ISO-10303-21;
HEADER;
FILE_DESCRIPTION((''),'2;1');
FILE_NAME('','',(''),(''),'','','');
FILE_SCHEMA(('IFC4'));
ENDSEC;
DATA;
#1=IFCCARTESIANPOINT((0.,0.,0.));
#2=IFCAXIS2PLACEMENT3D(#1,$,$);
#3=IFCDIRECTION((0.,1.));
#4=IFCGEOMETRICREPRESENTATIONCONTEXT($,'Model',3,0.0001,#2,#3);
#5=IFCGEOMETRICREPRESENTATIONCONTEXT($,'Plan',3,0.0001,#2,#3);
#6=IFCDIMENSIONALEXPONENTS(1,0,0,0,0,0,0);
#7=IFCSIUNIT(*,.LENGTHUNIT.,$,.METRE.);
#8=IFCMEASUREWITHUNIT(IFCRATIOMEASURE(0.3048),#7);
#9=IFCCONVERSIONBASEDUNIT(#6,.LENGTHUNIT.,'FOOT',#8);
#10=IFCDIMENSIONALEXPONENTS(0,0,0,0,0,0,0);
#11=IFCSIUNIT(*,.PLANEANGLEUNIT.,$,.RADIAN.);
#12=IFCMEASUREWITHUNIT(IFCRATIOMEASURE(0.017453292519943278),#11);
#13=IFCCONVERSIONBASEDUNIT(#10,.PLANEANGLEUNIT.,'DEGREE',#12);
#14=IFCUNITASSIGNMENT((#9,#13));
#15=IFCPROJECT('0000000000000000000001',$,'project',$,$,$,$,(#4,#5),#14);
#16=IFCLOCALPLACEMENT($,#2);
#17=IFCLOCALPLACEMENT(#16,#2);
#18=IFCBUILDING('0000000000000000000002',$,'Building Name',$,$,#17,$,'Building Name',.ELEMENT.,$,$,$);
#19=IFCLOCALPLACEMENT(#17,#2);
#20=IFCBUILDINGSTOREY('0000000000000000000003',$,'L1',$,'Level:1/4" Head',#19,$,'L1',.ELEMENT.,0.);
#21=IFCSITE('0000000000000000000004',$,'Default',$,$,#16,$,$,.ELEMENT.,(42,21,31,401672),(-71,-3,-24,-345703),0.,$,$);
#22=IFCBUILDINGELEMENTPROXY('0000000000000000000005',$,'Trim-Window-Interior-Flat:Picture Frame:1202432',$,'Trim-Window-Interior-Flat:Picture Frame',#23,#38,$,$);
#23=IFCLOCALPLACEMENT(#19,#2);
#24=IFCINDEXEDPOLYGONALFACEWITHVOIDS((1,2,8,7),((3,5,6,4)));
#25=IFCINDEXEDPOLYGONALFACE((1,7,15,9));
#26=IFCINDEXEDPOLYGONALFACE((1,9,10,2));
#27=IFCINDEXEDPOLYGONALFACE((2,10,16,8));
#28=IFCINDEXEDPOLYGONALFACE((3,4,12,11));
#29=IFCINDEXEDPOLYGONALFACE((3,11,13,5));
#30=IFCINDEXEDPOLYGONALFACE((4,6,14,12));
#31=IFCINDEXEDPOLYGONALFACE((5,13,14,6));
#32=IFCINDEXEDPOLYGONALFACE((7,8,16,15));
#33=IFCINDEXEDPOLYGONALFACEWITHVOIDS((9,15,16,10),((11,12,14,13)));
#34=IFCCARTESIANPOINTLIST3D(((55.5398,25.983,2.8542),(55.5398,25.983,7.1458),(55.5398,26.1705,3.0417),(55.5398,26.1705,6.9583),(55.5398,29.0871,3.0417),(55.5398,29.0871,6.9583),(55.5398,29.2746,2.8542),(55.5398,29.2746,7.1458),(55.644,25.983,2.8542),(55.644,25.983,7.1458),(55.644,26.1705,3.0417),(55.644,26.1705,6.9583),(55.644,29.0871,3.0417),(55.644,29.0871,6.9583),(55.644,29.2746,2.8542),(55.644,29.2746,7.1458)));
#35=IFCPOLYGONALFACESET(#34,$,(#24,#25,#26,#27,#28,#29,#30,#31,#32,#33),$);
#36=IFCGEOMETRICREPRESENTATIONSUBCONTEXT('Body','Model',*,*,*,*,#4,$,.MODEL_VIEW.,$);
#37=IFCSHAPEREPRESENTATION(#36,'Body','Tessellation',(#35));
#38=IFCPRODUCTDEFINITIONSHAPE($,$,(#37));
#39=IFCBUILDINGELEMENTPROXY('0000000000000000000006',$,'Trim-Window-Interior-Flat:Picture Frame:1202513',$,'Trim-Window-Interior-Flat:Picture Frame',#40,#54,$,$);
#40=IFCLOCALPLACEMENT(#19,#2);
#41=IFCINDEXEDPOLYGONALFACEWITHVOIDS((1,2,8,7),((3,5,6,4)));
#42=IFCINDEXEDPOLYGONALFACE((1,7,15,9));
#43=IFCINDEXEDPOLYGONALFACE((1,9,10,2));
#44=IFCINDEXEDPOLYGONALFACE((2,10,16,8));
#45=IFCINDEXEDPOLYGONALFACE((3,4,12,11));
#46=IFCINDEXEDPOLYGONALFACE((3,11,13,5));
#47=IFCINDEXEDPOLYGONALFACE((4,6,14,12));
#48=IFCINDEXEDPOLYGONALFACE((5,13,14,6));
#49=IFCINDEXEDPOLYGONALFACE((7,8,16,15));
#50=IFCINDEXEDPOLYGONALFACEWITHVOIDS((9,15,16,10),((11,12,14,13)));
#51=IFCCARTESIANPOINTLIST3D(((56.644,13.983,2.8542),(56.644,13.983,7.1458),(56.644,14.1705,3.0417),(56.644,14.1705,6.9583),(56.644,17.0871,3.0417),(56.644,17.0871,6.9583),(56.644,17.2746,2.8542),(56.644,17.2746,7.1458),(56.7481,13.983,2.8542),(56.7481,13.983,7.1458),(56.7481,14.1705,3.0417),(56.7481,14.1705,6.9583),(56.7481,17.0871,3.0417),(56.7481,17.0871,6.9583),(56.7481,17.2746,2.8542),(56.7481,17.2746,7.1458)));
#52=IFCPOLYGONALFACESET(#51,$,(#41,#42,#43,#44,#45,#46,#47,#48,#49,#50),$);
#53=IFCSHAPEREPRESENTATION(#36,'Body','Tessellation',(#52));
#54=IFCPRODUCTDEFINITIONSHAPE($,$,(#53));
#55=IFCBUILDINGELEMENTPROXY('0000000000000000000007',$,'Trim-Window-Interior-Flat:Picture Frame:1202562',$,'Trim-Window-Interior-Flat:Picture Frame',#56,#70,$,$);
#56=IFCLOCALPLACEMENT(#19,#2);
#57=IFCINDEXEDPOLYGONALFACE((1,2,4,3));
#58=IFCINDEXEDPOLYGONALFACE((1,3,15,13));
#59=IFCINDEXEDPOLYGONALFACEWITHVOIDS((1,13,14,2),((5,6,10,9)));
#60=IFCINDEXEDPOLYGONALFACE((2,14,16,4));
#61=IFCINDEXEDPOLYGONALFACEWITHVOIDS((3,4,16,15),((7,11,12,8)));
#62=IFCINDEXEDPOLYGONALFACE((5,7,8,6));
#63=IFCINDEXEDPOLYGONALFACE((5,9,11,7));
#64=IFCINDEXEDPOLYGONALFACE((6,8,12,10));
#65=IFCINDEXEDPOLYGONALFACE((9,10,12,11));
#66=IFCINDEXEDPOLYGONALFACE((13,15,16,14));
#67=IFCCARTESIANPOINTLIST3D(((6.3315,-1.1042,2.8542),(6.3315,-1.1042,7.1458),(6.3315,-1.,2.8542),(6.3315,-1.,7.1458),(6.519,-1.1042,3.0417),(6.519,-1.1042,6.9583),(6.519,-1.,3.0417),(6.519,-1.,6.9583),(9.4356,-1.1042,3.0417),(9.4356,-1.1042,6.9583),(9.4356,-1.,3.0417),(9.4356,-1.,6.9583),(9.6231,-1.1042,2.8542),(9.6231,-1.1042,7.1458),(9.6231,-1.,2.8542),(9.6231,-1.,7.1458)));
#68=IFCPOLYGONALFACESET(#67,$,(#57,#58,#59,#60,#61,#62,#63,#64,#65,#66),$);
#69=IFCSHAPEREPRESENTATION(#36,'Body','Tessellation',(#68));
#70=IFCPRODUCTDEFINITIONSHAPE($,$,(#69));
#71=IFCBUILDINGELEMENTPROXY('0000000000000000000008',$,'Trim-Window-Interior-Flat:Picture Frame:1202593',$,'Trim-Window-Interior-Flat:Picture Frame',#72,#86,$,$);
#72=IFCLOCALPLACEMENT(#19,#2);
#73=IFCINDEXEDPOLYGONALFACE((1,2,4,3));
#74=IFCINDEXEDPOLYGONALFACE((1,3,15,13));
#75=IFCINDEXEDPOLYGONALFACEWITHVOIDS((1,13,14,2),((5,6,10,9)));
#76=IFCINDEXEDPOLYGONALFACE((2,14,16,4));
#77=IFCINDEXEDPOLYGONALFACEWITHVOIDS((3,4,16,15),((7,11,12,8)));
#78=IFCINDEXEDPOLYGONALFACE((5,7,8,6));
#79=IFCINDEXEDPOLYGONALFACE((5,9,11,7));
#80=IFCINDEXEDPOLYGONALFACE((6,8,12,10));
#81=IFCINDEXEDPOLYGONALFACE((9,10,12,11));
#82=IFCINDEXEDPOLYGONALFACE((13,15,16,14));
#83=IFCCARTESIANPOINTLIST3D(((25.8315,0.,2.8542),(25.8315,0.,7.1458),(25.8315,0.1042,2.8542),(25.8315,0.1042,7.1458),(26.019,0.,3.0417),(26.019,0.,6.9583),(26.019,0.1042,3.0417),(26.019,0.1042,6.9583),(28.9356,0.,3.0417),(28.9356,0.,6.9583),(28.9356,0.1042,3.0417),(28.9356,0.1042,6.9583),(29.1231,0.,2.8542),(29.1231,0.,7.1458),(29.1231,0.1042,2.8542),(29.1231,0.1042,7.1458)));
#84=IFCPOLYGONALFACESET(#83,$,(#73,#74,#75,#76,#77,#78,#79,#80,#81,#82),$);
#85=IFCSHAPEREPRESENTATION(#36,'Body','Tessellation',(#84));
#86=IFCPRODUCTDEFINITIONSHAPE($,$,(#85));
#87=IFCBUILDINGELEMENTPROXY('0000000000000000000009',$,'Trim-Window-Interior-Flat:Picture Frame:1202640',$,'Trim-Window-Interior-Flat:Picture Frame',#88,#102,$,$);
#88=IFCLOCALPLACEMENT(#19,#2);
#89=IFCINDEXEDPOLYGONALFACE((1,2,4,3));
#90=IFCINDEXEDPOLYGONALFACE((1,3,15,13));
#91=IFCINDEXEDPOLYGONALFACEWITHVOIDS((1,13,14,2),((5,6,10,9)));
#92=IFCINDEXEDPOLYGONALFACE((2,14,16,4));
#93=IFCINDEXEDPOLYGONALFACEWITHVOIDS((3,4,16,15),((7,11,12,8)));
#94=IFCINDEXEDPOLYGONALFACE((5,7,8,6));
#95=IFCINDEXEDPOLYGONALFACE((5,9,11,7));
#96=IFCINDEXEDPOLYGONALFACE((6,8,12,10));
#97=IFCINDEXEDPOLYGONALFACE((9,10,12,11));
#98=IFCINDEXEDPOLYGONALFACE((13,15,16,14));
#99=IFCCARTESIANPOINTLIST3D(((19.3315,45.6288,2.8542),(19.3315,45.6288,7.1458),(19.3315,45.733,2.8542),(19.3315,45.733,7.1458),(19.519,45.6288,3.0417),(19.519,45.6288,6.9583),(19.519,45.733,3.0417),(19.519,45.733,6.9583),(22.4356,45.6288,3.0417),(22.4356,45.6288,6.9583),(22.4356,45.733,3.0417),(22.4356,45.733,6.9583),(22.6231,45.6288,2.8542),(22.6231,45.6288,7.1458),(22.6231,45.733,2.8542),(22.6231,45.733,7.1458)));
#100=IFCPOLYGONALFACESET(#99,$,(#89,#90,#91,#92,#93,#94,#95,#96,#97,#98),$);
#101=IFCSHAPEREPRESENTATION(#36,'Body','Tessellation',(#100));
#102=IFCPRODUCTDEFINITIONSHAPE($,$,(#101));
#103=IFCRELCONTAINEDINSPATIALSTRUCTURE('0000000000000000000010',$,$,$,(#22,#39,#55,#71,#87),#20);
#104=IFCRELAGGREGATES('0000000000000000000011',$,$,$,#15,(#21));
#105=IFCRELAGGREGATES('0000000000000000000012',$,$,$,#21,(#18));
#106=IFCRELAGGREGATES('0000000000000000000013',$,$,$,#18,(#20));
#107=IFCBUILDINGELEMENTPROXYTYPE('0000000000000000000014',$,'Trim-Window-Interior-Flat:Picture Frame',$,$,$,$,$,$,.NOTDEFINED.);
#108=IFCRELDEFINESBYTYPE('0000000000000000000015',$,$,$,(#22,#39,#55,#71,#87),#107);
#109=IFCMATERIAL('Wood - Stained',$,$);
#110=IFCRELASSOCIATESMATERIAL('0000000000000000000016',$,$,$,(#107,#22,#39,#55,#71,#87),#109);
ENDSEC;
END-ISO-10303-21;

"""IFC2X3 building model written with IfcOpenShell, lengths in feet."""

from ifc_helpers import new_model, entity, si_unit, converted_unit, direction, frame, origin, place, context, subcontext, project, spatial, polyline, outline, extrude, source, transform, mapped, material, type_object, type_shapes, element, save


model = new_model("IFC2X3")

# Units and contexts
model_context = context("Model", 3, precision=0.0001, world=origin(), true_north=direction((0.0, 1.0)))
plan_context = context("Plan", 3, precision=0.0001, world=origin(), true_north=direction((0.0, 1.0)))
body_context = subcontext(model_context, "Body", "Model", "MODEL_VIEW")
ifc_project = project(units=[converted_unit("LENGTHUNIT", "FOOT", entity("IfcRatioMeasure", 0.3048), si_unit("LENGTHUNIT", "METRE"), dimensions=[1, 0, 0, 0, 0, 0, 0]), converted_unit("PLANEANGLEUNIT", "DEGREE", entity("IfcRatioMeasure", 0.017453292519943278), si_unit("PLANEANGLEUNIT", "RADIAN"), dimensions=[0, 0, 0, 0, 0, 0, 0])], contexts=[model_context, plan_context])

# Site, building, storey
site_placement = place(None, origin())
site = spatial("IfcSite", under=ifc_project, at=site_placement, Name="Default", CompositionType="ELEMENT", RefLatitude=(42, 21, 31, 401672), RefLongitude=(-71, -3, -24, -345703), RefElevation=0.0)
building_placement = place(site_placement, origin())
building = spatial("IfcBuilding", under=site, at=building_placement, Name="Building Name", LongName="Building Name", CompositionType="ELEMENT")
storey_placement = place(building_placement, origin())
storey = spatial("IfcBuildingStorey", under=building, at=storey_placement, Name="L1", ObjectType="Level:1/4\" Head", LongName="L1", CompositionType="ELEMENT", Elevation=0.0)

# Building element proxies
ifc_material_1 = material(Name="Wood - Stained")
building_element_proxy_type_1 = type_object("IfcBuildingElementProxyType", Name="Trim-Window-Interior-Flat:Picture Frame", PredefinedType="NOTDEFINED", material=ifc_material_1)
shared_shape_1 = source(origin(), body_context, "Body", "SweptSolid", [
    extrude(outline(polyline([(-1.6458, -2.1458), (1.6458, -2.1458), (1.6458, 2.1458), (-1.6458, 2.1458), (-1.6458, -2.1458)]), holes=[polyline([(-1.4583, -1.9583), (-1.4583, 1.9583), (1.4583, 1.9583), (1.4583, -1.9583), (-1.4583, -1.9583)])]), frame((0.0, -2.0, 0.0), z_axis=(0.0, 0.0, 1.0), x_axis=(-1.0, 0.0, 0.0)), (0.0, 0.0, 1.0), 0.1042),
])
type_shapes(building_element_proxy_type_1, [shared_shape_1])
for number, where, z_axis, x_axis, name in (
    (1, (55.644, 27.6288, 7.0), (-1.0, 0.0, 0.0), (0.0, -1.0, 0.0), "Trim-Window-Interior-Flat:Picture Frame:1202432"),
    (2, (56.644, 15.6288, 7.0), (1.0, 0.0, 0.0), (0.0, 1.0, 0.0), "Trim-Window-Interior-Flat:Picture Frame:1202513"),
    (3, (7.9773, -1.0, 7.0), (0.0, -1.0, 0.0), (1.0, 0.0, 0.0), "Trim-Window-Interior-Flat:Picture Frame:1202562"),
    (4, (27.4773, 0.0, 7.0), (0.0, 1.0, 0.0), (-1.0, 0.0, 0.0), "Trim-Window-Interior-Flat:Picture Frame:1202593"),
    (5, (20.9773, 45.6288, 7.0), (0.0, 1.0, 0.0), (-1.0, 0.0, 0.0), "Trim-Window-Interior-Flat:Picture Frame:1202640"),
):
    element("IfcBuildingElementProxy", number, at=place(storey_placement, frame(where, z_axis=z_axis, x_axis=x_axis)), inside=storey, type_object=building_element_proxy_type_1, material=ifc_material_1, Name=name, ObjectType="Trim-Window-Interior-Flat:Picture Frame", context=body_context, shape_type="MappedRepresentation", body=[
        mapped(shared_shape_1, transform((0.0, 0.0, 0.0), scale=1.0)),
    ])

save(model, "model.ifc")
